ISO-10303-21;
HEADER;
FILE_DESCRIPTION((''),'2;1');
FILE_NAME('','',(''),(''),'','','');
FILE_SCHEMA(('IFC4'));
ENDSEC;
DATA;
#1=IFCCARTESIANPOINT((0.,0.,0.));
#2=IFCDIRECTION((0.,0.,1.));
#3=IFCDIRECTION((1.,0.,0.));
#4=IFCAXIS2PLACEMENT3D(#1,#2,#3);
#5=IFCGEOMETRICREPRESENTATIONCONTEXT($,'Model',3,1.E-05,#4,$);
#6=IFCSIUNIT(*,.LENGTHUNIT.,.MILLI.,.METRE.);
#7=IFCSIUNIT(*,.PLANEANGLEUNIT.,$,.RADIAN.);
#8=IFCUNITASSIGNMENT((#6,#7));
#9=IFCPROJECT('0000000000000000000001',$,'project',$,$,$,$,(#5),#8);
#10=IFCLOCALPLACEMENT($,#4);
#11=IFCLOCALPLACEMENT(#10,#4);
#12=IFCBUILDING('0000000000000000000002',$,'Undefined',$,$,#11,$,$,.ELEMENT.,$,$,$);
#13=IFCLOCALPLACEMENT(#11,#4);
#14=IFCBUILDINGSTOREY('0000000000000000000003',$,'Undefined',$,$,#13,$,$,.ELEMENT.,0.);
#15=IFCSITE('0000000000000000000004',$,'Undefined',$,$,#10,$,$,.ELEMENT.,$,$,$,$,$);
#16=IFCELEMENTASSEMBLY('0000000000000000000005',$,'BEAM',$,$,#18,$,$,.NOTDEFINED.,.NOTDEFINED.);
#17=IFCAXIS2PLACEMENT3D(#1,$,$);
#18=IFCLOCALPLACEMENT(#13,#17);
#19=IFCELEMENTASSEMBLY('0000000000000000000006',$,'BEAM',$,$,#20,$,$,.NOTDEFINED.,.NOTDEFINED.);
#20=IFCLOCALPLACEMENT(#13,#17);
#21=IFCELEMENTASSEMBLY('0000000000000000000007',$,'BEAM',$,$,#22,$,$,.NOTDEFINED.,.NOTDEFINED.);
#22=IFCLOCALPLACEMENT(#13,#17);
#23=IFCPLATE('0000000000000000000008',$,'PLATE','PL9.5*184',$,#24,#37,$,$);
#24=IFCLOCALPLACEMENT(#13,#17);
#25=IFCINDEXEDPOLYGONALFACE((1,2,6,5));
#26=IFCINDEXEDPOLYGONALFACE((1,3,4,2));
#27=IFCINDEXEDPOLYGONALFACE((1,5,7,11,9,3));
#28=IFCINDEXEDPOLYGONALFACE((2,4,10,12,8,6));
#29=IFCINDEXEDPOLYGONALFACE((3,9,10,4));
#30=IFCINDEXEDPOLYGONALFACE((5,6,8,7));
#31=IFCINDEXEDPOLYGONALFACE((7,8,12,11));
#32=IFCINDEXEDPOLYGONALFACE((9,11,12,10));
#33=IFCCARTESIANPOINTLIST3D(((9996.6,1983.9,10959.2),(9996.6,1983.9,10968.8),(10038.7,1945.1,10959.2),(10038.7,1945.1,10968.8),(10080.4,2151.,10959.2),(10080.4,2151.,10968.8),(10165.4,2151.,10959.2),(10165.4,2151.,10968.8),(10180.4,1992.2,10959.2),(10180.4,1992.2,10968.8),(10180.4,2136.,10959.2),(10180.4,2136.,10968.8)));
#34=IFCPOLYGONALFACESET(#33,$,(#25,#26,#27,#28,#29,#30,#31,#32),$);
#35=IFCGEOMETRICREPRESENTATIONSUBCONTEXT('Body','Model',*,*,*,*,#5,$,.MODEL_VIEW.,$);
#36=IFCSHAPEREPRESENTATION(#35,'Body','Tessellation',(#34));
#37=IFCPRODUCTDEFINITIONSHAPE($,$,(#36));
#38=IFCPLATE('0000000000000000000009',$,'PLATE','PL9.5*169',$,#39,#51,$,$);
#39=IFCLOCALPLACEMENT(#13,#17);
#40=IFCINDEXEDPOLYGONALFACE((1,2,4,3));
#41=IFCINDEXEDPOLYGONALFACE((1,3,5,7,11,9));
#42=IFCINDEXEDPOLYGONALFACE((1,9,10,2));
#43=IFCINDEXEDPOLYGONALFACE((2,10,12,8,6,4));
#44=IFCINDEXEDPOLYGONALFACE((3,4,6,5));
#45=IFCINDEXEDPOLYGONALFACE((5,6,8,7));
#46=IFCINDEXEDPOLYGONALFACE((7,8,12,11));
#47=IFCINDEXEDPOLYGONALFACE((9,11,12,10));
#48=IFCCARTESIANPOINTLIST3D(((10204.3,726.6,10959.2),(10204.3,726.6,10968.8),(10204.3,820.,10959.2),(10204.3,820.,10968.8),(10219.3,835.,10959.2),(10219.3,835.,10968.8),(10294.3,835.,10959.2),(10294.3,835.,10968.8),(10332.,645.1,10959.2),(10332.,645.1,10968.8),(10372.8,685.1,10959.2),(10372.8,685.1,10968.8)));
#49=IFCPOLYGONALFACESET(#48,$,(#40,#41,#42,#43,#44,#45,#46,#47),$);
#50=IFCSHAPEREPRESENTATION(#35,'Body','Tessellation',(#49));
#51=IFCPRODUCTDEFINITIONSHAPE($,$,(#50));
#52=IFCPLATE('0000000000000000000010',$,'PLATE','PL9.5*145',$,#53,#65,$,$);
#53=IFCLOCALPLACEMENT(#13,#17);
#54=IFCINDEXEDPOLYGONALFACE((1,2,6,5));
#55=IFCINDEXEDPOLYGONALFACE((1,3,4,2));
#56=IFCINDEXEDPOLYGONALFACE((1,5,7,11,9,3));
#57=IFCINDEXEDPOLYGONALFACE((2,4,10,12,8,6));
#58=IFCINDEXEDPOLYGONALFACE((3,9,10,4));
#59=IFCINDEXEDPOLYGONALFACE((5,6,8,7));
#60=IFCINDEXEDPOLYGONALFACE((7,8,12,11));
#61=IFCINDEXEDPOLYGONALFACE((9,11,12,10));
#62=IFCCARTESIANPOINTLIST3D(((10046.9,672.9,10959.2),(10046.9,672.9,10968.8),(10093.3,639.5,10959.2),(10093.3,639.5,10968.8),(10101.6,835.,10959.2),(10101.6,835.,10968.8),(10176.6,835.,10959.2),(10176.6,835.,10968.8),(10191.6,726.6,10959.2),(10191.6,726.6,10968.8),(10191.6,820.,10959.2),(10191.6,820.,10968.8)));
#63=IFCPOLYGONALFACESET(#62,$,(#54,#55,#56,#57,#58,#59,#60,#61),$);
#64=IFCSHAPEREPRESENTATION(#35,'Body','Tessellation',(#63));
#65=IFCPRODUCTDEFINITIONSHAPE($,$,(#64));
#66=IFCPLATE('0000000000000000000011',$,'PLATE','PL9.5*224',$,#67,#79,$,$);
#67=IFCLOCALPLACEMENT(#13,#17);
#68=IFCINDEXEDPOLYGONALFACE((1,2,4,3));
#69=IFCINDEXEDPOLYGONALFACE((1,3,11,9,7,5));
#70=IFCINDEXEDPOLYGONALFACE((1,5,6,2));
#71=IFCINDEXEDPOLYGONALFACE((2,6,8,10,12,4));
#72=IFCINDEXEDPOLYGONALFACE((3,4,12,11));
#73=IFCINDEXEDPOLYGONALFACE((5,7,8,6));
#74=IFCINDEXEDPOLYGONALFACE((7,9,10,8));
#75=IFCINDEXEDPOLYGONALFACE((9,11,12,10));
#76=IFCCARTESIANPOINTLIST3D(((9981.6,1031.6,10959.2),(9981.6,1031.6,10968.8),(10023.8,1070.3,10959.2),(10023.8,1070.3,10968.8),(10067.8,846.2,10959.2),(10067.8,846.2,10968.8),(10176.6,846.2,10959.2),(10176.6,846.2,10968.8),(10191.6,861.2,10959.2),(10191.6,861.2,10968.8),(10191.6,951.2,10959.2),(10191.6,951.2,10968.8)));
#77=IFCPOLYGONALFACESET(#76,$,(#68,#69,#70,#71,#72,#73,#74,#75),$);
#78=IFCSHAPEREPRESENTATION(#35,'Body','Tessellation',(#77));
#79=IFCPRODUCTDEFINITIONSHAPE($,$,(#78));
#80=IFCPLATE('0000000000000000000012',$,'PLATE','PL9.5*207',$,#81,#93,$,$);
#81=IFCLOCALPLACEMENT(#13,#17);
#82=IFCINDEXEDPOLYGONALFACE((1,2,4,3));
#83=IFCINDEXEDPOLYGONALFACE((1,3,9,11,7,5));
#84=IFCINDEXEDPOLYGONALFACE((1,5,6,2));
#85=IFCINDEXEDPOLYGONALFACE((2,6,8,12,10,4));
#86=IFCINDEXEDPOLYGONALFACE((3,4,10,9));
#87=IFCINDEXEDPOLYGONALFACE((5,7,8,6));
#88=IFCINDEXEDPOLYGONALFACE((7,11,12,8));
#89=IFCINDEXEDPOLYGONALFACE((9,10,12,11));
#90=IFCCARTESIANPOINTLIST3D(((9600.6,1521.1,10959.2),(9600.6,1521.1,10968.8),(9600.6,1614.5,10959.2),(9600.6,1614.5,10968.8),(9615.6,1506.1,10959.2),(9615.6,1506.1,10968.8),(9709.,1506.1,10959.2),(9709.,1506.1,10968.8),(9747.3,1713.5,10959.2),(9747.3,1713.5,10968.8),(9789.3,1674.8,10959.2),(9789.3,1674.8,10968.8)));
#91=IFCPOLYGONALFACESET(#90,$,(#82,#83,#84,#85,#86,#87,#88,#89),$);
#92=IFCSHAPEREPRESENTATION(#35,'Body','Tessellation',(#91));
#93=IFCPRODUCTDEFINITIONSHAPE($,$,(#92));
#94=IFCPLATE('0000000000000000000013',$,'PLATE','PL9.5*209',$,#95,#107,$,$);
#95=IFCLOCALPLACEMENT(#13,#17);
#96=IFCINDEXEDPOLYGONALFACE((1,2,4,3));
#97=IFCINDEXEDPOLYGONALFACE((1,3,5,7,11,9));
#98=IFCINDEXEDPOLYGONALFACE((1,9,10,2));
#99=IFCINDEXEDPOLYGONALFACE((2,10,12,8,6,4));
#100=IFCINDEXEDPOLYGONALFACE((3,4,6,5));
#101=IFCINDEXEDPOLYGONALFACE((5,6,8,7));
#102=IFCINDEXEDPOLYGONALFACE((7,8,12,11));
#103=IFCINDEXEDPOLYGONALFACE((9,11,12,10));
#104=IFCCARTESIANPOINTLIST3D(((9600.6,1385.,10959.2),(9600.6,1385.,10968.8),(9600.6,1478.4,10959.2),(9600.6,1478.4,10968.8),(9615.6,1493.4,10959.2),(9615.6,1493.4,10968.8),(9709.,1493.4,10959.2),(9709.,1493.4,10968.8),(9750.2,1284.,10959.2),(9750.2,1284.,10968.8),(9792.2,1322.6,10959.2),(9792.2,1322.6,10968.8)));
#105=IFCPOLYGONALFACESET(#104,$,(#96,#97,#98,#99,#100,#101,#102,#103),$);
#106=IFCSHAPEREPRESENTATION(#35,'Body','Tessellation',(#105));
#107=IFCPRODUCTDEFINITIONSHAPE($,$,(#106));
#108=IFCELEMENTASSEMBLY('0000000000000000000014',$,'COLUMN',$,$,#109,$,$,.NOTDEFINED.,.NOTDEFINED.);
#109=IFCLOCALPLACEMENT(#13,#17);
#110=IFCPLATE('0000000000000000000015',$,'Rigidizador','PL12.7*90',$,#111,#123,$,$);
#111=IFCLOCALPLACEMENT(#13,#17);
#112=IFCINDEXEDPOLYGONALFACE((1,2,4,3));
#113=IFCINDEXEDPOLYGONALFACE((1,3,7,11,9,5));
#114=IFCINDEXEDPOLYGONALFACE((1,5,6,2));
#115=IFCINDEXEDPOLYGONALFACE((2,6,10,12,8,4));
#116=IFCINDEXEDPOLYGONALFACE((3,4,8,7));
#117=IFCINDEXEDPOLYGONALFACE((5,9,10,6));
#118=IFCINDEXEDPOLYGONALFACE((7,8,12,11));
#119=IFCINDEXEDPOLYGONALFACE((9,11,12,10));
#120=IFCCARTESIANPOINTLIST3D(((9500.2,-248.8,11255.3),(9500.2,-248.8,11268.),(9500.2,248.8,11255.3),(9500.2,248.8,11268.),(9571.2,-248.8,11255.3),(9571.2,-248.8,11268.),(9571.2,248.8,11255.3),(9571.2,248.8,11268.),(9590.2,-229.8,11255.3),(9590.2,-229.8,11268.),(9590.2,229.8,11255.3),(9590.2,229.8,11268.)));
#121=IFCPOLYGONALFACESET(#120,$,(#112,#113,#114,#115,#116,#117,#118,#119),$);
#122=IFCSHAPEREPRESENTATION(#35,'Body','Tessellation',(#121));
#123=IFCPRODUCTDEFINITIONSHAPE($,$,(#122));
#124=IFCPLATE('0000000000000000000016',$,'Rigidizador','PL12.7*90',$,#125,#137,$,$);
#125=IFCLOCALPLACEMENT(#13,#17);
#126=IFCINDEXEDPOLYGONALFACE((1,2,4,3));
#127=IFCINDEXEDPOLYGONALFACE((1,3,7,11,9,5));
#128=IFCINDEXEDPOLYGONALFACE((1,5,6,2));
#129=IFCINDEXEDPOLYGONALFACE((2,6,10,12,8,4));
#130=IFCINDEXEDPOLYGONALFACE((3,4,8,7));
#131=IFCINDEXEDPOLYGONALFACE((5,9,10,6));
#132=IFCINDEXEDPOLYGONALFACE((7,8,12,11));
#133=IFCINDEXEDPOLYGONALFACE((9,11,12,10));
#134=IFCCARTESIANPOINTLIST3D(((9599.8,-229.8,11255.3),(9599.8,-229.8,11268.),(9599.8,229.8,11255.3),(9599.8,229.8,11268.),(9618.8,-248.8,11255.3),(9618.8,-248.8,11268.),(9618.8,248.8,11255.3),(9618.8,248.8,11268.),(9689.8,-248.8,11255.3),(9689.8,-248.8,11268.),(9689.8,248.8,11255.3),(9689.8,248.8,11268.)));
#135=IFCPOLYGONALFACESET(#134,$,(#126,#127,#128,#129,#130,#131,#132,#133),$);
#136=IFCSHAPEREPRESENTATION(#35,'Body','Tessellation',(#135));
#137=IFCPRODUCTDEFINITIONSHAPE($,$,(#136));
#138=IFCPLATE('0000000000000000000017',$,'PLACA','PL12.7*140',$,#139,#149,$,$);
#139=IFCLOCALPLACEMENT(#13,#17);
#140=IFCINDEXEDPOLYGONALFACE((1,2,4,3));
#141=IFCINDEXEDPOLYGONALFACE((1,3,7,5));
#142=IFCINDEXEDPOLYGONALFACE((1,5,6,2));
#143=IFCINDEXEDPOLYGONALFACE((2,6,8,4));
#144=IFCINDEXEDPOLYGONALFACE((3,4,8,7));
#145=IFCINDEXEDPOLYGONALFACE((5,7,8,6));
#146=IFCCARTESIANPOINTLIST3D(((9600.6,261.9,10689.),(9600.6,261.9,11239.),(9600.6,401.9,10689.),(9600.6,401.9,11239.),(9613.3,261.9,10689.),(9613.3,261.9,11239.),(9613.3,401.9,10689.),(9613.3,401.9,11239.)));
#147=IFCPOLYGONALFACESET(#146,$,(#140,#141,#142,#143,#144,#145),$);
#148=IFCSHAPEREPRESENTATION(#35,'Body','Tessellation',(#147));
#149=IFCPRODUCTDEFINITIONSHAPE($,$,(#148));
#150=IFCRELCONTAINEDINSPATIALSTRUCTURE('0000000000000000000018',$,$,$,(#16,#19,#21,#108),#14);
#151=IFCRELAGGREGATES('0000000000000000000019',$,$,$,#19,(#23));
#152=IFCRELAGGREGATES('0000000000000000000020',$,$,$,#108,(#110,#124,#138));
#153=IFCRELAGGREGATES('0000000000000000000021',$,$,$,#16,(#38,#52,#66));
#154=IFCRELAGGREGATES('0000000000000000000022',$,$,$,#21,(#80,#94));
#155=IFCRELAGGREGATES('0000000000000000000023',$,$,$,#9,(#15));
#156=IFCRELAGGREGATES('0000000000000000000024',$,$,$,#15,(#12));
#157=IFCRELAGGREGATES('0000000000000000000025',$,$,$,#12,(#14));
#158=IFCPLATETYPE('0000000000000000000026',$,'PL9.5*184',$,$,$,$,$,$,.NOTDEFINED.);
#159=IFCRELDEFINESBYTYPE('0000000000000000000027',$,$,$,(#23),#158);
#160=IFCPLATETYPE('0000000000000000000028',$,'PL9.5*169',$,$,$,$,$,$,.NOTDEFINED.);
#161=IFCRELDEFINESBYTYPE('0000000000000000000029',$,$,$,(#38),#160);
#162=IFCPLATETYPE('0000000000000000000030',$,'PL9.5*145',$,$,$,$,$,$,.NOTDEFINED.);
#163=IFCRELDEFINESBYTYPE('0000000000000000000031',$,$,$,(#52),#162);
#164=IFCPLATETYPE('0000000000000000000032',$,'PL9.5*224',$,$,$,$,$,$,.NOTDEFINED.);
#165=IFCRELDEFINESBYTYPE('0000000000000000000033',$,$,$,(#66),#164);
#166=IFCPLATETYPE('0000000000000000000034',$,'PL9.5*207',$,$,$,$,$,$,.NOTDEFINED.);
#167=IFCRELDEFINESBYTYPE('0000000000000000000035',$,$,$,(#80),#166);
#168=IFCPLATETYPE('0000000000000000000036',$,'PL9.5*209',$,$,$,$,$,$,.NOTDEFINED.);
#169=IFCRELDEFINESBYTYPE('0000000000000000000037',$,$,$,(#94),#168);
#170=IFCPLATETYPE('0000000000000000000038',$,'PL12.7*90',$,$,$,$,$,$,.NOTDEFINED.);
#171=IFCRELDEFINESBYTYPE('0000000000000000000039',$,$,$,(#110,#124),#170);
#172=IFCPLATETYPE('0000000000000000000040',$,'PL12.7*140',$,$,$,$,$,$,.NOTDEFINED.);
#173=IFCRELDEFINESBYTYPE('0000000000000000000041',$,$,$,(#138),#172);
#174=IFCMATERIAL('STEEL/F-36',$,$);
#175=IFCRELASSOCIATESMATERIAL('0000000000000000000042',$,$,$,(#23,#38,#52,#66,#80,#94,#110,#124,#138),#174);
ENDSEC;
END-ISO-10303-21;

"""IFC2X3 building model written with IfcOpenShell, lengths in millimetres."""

from ifc_helpers import new_model, si_unit, frame, origin_with_axes, place, context, subcontext, project, spatial, polyline, outline, extrude, material, type_object, element, aggregate, save


model = new_model("IFC2X3")

# Units and contexts
model_context = context("Model", 3, precision=1e-05, world=origin_with_axes())
body_context = subcontext(model_context, "Body", "Model", "MODEL_VIEW")
ifc_project = project(units=[si_unit("LENGTHUNIT", "METRE", prefix="MILLI"), si_unit("PLANEANGLEUNIT", "RADIAN")], contexts=[model_context])

# Site, building, storey
site_placement = place(None, origin_with_axes())
site = spatial("IfcSite", under=ifc_project, at=site_placement, Name="Undefined", CompositionType="ELEMENT")
building_placement = place(site_placement, origin_with_axes())
building = spatial("IfcBuilding", under=site, at=building_placement, Name="Undefined", CompositionType="ELEMENT")
storey_placement = place(building_placement, origin_with_axes())
storey = spatial("IfcBuildingStorey", under=building, at=storey_placement, Name="Undefined", CompositionType="ELEMENT", Elevation=0.0)

# Element assembly
ifc_material_1 = material(Name="STEEL/F-36")
assembly_1_placement = place(storey_placement, origin_with_axes())
assembly_1 = element("IfcElementAssembly", 1, at=assembly_1_placement, inside=storey, Name="BEAM", AssemblyPlace="NOTDEFINED", PredefinedType="NOTDEFINED")

# Element assembly
assembly_2_placement = place(storey_placement, origin_with_axes())
assembly_2 = element("IfcElementAssembly", 2, at=assembly_2_placement, inside=storey, Name="BEAM", AssemblyPlace="NOTDEFINED", PredefinedType="NOTDEFINED")

# Element assembly
assembly_3_placement = place(storey_placement, origin_with_axes())
assembly_3 = element("IfcElementAssembly", 3, at=assembly_3_placement, inside=storey, Name="BEAM", AssemblyPlace="NOTDEFINED", PredefinedType="NOTDEFINED")

# Plates
plate_type_1 = type_object("IfcPlateType", Name="PL9.5*184", PredefinedType="NOTDEFINED")
plate_1_placement = place(assembly_2_placement, frame((10080.4, 2151.0, 10964.0), z_axis=(0.0, 0.0, -1.0), x_axis=(1.0, 0.0, 0.0)))
plate_1 = element("IfcPlate", 4, at=plate_1_placement, type_object=plate_type_1, material=ifc_material_1, Name="PLATE", Description="PL9.5*184", context=body_context, shape_type="SweptSolid", body=[
    extrude(outline(polyline([(0.0, 0.0), (85.0, 0.0), (100.0, 15.0), (100.0, 158.8), (-41.7, 205.8), (-83.8, 167.1), (0.0, 0.0)])), frame((0.0, 0.0, -4.8), z_axis=(0.0, 0.0, 1.0), x_axis=(1.0, 0.0, 0.0)), (0.0, 0.0, 1.0), 9.5),
])
aggregate(assembly_2, [plate_1])
plate_type_2 = type_object("IfcPlateType", Name="PL9.5*169", PredefinedType="NOTDEFINED")
plate_2_placement = place(assembly_1_placement, frame((10204.3, 726.6, 10964.0), z_axis=(0.0, 0.0, -1.0), x_axis=(0.0, 1.0, 0.0)))
plate_2 = element("IfcPlate", 5, at=plate_2_placement, type_object=plate_type_2, material=ifc_material_1, Name="PLATE", Description="PL9.5*169", context=body_context, shape_type="SweptSolid", body=[
    extrude(outline(polyline([(0.0, 0.0), (93.4, 0.0), (108.4, 15.0), (108.4, 90.0), (-41.4, 168.5), (-81.5, 127.7), (0.0, 0.0)])), frame((0.0, 0.0, -4.8), z_axis=(0.0, 0.0, 1.0), x_axis=(1.0, 0.0, 0.0)), (0.0, 0.0, 1.0), 9.5),
])
plate_type_3 = type_object("IfcPlateType", Name="PL9.5*145", PredefinedType="NOTDEFINED")
plate_3_placement = place(assembly_1_placement, frame((10191.6, 726.6, 10964.0), z_axis=(0.0, 0.0, 1.0), x_axis=(0.0, 1.0, 0.0)))
plate_3 = element("IfcPlate", 6, at=plate_3_placement, type_object=plate_type_3, material=ifc_material_1, Name="PLATE", Description="PL9.5*145", context=body_context, shape_type="SweptSolid", body=[
    extrude(outline(polyline([(0.0, 0.0), (93.4, 0.0), (108.4, 15.0), (108.4, 90.0), (-53.7, 144.7), (-87.1, 98.3), (0.0, 0.0)])), frame((0.0, 0.0, -4.8), z_axis=(0.0, 0.0, 1.0), x_axis=(1.0, 0.0, 0.0)), (0.0, 0.0, 1.0), 9.5),
])
plate_type_4 = type_object("IfcPlateType", Name="PL9.5*224", PredefinedType="NOTDEFINED")
plate_4_placement = place(assembly_1_placement, frame((10067.8, 846.2, 10964.0), z_axis=(0.0, 0.0, 1.0), x_axis=(1.0, 0.0, 0.0)))
plate_4 = element("IfcPlate", 7, at=plate_4_placement, type_object=plate_type_4, material=ifc_material_1, Name="PLATE", Description="PL9.5*224", context=body_context, shape_type="SweptSolid", body=[
    extrude(outline(polyline([(0.0, 0.0), (108.8, 0.0), (123.8, 15.0), (123.8, 105.0), (-44.0, 224.1), (-86.2, 185.5), (0.0, 0.0)])), frame((0.0, 0.0, -4.8), z_axis=(0.0, 0.0, 1.0), x_axis=(1.0, 0.0, 0.0)), (0.0, 0.0, 1.0), 9.5),
])
plate_type_5 = type_object("IfcPlateType", Name="PL9.5*207", PredefinedType="NOTDEFINED")
plate_5_placement = place(assembly_3_placement, frame((9600.6, 1614.5, 10964.0), z_axis=(0.0, 0.0, 1.0), x_axis=(0.0, -1.0, 0.0)))
plate_5 = element("IfcPlate", 8, at=plate_5_placement, type_object=plate_type_5, material=ifc_material_1, Name="PLATE", Description="PL9.5*207", context=body_context, shape_type="SweptSolid", body=[
    extrude(outline(polyline([(0.0, 0.0), (93.4, 0.0), (108.4, 15.0), (108.4, 108.4), (-60.4, 188.7), (-99.1, 146.7), (0.0, 0.0)])), frame((0.0, 0.0, -4.8), z_axis=(0.0, 0.0, 1.0), x_axis=(1.0, 0.0, 0.0)), (0.0, 0.0, 1.0), 9.5),
])
plate_type_6 = type_object("IfcPlateType", Name="PL9.5*209", PredefinedType="NOTDEFINED")
plate_6_placement = place(assembly_3_placement, frame((9600.6, 1385.0, 10964.0), z_axis=(0.0, 0.0, -1.0), x_axis=(0.0, 1.0, 0.0)))
plate_6 = element("IfcPlate", 9, at=plate_6_placement, type_object=plate_type_6, material=ifc_material_1, Name="PLATE", Description="PL9.5*209", context=body_context, shape_type="SweptSolid", body=[
    extrude(outline(polyline([(0.0, 0.0), (93.4, 0.0), (108.4, 15.0), (108.4, 108.4), (-62.3, 191.6), (-100.9, 149.6), (0.0, 0.0)])), frame((0.0, 0.0, -4.8), z_axis=(0.0, 0.0, 1.0), x_axis=(1.0, 0.0, 0.0)), (0.0, 0.0, 1.0), 9.5),
])

# Element assembly, plates
assembly_4_placement = place(storey_placement, origin_with_axes())
assembly_4 = element("IfcElementAssembly", 10, at=assembly_4_placement, inside=storey, Name="COLUMN", AssemblyPlace="NOTDEFINED", PredefinedType="NOTDEFINED")
plate_type_7 = type_object("IfcPlateType", Name="PL12.7*90", PredefinedType="NOTDEFINED")
plate_7_placement = place(assembly_4_placement, frame((9590.2, -248.8, 11261.6), z_axis=(0.0, 0.0, -1.0), x_axis=(-1.0, 0.0, 0.0)))
plate_7 = element("IfcPlate", 11, at=plate_7_placement, type_object=plate_type_7, material=ifc_material_1, Name="Rigidizador", Description="PL12.7*90", context=body_context, shape_type="SweptSolid", body=[
    extrude(outline(polyline([(0.0, 19.0), (19.0, 0.0), (90.0, 0.0), (90.0, 497.6), (19.0, 497.6), (0.0, 478.6), (0.0, 19.0)])), frame((0.0, 0.0, -6.3), z_axis=(0.0, 0.0, 1.0), x_axis=(1.0, 0.0, 0.0)), (0.0, 0.0, 1.0), 12.7),
])
plate_8_placement = place(assembly_4_placement, frame((9689.8, -248.8, 11261.6), z_axis=(0.0, 0.0, -1.0), x_axis=(-1.0, 0.0, 0.0)))
plate_8 = element("IfcPlate", 12, at=plate_8_placement, type_object=plate_type_7, material=ifc_material_1, Name="Rigidizador", Description="PL12.7*90", context=body_context, shape_type="SweptSolid", body=[
    extrude(outline(polyline([(0.0, 0.0), (71.0, 0.0), (90.0, 19.0), (90.0, 478.6), (71.0, 497.6), (0.0, 497.6), (0.0, 0.0)])), frame((0.0, 0.0, -6.3), z_axis=(0.0, 0.0, 1.0), x_axis=(1.0, 0.0, 0.0)), (0.0, 0.0, 1.0), 12.7),
])
plate_type_8 = type_object("IfcPlateType", Name="PL12.7*140", PredefinedType="NOTDEFINED")
plate_9_placement = place(assembly_4_placement, frame((9606.9, 261.9, 11239.0), z_axis=(1.0, 0.0, 0.0), x_axis=(0.0, 0.0, -1.0)))
plate_9 = element("IfcPlate", 13, at=plate_9_placement, type_object=plate_type_8, material=ifc_material_1, Name="PLACA", Description="PL12.7*140", context=body_context, shape_type="SweptSolid", body=[
    extrude(outline(polyline([(0.0, 0.0), (550.0, 0.0), (550.0, 140.0), (0.0, 140.0), (0.0, 0.0)])), frame((0.0, 0.0, -6.3), z_axis=(0.0, 0.0, 1.0), x_axis=(1.0, 0.0, 0.0)), (0.0, 0.0, 1.0), 12.7),
])
aggregate(assembly_4, [plate_7, plate_8, plate_9])

aggregate(assembly_1, [plate_2, plate_3, plate_4])
aggregate(assembly_3, [plate_5, plate_6])

save(model, "model.ifc")
